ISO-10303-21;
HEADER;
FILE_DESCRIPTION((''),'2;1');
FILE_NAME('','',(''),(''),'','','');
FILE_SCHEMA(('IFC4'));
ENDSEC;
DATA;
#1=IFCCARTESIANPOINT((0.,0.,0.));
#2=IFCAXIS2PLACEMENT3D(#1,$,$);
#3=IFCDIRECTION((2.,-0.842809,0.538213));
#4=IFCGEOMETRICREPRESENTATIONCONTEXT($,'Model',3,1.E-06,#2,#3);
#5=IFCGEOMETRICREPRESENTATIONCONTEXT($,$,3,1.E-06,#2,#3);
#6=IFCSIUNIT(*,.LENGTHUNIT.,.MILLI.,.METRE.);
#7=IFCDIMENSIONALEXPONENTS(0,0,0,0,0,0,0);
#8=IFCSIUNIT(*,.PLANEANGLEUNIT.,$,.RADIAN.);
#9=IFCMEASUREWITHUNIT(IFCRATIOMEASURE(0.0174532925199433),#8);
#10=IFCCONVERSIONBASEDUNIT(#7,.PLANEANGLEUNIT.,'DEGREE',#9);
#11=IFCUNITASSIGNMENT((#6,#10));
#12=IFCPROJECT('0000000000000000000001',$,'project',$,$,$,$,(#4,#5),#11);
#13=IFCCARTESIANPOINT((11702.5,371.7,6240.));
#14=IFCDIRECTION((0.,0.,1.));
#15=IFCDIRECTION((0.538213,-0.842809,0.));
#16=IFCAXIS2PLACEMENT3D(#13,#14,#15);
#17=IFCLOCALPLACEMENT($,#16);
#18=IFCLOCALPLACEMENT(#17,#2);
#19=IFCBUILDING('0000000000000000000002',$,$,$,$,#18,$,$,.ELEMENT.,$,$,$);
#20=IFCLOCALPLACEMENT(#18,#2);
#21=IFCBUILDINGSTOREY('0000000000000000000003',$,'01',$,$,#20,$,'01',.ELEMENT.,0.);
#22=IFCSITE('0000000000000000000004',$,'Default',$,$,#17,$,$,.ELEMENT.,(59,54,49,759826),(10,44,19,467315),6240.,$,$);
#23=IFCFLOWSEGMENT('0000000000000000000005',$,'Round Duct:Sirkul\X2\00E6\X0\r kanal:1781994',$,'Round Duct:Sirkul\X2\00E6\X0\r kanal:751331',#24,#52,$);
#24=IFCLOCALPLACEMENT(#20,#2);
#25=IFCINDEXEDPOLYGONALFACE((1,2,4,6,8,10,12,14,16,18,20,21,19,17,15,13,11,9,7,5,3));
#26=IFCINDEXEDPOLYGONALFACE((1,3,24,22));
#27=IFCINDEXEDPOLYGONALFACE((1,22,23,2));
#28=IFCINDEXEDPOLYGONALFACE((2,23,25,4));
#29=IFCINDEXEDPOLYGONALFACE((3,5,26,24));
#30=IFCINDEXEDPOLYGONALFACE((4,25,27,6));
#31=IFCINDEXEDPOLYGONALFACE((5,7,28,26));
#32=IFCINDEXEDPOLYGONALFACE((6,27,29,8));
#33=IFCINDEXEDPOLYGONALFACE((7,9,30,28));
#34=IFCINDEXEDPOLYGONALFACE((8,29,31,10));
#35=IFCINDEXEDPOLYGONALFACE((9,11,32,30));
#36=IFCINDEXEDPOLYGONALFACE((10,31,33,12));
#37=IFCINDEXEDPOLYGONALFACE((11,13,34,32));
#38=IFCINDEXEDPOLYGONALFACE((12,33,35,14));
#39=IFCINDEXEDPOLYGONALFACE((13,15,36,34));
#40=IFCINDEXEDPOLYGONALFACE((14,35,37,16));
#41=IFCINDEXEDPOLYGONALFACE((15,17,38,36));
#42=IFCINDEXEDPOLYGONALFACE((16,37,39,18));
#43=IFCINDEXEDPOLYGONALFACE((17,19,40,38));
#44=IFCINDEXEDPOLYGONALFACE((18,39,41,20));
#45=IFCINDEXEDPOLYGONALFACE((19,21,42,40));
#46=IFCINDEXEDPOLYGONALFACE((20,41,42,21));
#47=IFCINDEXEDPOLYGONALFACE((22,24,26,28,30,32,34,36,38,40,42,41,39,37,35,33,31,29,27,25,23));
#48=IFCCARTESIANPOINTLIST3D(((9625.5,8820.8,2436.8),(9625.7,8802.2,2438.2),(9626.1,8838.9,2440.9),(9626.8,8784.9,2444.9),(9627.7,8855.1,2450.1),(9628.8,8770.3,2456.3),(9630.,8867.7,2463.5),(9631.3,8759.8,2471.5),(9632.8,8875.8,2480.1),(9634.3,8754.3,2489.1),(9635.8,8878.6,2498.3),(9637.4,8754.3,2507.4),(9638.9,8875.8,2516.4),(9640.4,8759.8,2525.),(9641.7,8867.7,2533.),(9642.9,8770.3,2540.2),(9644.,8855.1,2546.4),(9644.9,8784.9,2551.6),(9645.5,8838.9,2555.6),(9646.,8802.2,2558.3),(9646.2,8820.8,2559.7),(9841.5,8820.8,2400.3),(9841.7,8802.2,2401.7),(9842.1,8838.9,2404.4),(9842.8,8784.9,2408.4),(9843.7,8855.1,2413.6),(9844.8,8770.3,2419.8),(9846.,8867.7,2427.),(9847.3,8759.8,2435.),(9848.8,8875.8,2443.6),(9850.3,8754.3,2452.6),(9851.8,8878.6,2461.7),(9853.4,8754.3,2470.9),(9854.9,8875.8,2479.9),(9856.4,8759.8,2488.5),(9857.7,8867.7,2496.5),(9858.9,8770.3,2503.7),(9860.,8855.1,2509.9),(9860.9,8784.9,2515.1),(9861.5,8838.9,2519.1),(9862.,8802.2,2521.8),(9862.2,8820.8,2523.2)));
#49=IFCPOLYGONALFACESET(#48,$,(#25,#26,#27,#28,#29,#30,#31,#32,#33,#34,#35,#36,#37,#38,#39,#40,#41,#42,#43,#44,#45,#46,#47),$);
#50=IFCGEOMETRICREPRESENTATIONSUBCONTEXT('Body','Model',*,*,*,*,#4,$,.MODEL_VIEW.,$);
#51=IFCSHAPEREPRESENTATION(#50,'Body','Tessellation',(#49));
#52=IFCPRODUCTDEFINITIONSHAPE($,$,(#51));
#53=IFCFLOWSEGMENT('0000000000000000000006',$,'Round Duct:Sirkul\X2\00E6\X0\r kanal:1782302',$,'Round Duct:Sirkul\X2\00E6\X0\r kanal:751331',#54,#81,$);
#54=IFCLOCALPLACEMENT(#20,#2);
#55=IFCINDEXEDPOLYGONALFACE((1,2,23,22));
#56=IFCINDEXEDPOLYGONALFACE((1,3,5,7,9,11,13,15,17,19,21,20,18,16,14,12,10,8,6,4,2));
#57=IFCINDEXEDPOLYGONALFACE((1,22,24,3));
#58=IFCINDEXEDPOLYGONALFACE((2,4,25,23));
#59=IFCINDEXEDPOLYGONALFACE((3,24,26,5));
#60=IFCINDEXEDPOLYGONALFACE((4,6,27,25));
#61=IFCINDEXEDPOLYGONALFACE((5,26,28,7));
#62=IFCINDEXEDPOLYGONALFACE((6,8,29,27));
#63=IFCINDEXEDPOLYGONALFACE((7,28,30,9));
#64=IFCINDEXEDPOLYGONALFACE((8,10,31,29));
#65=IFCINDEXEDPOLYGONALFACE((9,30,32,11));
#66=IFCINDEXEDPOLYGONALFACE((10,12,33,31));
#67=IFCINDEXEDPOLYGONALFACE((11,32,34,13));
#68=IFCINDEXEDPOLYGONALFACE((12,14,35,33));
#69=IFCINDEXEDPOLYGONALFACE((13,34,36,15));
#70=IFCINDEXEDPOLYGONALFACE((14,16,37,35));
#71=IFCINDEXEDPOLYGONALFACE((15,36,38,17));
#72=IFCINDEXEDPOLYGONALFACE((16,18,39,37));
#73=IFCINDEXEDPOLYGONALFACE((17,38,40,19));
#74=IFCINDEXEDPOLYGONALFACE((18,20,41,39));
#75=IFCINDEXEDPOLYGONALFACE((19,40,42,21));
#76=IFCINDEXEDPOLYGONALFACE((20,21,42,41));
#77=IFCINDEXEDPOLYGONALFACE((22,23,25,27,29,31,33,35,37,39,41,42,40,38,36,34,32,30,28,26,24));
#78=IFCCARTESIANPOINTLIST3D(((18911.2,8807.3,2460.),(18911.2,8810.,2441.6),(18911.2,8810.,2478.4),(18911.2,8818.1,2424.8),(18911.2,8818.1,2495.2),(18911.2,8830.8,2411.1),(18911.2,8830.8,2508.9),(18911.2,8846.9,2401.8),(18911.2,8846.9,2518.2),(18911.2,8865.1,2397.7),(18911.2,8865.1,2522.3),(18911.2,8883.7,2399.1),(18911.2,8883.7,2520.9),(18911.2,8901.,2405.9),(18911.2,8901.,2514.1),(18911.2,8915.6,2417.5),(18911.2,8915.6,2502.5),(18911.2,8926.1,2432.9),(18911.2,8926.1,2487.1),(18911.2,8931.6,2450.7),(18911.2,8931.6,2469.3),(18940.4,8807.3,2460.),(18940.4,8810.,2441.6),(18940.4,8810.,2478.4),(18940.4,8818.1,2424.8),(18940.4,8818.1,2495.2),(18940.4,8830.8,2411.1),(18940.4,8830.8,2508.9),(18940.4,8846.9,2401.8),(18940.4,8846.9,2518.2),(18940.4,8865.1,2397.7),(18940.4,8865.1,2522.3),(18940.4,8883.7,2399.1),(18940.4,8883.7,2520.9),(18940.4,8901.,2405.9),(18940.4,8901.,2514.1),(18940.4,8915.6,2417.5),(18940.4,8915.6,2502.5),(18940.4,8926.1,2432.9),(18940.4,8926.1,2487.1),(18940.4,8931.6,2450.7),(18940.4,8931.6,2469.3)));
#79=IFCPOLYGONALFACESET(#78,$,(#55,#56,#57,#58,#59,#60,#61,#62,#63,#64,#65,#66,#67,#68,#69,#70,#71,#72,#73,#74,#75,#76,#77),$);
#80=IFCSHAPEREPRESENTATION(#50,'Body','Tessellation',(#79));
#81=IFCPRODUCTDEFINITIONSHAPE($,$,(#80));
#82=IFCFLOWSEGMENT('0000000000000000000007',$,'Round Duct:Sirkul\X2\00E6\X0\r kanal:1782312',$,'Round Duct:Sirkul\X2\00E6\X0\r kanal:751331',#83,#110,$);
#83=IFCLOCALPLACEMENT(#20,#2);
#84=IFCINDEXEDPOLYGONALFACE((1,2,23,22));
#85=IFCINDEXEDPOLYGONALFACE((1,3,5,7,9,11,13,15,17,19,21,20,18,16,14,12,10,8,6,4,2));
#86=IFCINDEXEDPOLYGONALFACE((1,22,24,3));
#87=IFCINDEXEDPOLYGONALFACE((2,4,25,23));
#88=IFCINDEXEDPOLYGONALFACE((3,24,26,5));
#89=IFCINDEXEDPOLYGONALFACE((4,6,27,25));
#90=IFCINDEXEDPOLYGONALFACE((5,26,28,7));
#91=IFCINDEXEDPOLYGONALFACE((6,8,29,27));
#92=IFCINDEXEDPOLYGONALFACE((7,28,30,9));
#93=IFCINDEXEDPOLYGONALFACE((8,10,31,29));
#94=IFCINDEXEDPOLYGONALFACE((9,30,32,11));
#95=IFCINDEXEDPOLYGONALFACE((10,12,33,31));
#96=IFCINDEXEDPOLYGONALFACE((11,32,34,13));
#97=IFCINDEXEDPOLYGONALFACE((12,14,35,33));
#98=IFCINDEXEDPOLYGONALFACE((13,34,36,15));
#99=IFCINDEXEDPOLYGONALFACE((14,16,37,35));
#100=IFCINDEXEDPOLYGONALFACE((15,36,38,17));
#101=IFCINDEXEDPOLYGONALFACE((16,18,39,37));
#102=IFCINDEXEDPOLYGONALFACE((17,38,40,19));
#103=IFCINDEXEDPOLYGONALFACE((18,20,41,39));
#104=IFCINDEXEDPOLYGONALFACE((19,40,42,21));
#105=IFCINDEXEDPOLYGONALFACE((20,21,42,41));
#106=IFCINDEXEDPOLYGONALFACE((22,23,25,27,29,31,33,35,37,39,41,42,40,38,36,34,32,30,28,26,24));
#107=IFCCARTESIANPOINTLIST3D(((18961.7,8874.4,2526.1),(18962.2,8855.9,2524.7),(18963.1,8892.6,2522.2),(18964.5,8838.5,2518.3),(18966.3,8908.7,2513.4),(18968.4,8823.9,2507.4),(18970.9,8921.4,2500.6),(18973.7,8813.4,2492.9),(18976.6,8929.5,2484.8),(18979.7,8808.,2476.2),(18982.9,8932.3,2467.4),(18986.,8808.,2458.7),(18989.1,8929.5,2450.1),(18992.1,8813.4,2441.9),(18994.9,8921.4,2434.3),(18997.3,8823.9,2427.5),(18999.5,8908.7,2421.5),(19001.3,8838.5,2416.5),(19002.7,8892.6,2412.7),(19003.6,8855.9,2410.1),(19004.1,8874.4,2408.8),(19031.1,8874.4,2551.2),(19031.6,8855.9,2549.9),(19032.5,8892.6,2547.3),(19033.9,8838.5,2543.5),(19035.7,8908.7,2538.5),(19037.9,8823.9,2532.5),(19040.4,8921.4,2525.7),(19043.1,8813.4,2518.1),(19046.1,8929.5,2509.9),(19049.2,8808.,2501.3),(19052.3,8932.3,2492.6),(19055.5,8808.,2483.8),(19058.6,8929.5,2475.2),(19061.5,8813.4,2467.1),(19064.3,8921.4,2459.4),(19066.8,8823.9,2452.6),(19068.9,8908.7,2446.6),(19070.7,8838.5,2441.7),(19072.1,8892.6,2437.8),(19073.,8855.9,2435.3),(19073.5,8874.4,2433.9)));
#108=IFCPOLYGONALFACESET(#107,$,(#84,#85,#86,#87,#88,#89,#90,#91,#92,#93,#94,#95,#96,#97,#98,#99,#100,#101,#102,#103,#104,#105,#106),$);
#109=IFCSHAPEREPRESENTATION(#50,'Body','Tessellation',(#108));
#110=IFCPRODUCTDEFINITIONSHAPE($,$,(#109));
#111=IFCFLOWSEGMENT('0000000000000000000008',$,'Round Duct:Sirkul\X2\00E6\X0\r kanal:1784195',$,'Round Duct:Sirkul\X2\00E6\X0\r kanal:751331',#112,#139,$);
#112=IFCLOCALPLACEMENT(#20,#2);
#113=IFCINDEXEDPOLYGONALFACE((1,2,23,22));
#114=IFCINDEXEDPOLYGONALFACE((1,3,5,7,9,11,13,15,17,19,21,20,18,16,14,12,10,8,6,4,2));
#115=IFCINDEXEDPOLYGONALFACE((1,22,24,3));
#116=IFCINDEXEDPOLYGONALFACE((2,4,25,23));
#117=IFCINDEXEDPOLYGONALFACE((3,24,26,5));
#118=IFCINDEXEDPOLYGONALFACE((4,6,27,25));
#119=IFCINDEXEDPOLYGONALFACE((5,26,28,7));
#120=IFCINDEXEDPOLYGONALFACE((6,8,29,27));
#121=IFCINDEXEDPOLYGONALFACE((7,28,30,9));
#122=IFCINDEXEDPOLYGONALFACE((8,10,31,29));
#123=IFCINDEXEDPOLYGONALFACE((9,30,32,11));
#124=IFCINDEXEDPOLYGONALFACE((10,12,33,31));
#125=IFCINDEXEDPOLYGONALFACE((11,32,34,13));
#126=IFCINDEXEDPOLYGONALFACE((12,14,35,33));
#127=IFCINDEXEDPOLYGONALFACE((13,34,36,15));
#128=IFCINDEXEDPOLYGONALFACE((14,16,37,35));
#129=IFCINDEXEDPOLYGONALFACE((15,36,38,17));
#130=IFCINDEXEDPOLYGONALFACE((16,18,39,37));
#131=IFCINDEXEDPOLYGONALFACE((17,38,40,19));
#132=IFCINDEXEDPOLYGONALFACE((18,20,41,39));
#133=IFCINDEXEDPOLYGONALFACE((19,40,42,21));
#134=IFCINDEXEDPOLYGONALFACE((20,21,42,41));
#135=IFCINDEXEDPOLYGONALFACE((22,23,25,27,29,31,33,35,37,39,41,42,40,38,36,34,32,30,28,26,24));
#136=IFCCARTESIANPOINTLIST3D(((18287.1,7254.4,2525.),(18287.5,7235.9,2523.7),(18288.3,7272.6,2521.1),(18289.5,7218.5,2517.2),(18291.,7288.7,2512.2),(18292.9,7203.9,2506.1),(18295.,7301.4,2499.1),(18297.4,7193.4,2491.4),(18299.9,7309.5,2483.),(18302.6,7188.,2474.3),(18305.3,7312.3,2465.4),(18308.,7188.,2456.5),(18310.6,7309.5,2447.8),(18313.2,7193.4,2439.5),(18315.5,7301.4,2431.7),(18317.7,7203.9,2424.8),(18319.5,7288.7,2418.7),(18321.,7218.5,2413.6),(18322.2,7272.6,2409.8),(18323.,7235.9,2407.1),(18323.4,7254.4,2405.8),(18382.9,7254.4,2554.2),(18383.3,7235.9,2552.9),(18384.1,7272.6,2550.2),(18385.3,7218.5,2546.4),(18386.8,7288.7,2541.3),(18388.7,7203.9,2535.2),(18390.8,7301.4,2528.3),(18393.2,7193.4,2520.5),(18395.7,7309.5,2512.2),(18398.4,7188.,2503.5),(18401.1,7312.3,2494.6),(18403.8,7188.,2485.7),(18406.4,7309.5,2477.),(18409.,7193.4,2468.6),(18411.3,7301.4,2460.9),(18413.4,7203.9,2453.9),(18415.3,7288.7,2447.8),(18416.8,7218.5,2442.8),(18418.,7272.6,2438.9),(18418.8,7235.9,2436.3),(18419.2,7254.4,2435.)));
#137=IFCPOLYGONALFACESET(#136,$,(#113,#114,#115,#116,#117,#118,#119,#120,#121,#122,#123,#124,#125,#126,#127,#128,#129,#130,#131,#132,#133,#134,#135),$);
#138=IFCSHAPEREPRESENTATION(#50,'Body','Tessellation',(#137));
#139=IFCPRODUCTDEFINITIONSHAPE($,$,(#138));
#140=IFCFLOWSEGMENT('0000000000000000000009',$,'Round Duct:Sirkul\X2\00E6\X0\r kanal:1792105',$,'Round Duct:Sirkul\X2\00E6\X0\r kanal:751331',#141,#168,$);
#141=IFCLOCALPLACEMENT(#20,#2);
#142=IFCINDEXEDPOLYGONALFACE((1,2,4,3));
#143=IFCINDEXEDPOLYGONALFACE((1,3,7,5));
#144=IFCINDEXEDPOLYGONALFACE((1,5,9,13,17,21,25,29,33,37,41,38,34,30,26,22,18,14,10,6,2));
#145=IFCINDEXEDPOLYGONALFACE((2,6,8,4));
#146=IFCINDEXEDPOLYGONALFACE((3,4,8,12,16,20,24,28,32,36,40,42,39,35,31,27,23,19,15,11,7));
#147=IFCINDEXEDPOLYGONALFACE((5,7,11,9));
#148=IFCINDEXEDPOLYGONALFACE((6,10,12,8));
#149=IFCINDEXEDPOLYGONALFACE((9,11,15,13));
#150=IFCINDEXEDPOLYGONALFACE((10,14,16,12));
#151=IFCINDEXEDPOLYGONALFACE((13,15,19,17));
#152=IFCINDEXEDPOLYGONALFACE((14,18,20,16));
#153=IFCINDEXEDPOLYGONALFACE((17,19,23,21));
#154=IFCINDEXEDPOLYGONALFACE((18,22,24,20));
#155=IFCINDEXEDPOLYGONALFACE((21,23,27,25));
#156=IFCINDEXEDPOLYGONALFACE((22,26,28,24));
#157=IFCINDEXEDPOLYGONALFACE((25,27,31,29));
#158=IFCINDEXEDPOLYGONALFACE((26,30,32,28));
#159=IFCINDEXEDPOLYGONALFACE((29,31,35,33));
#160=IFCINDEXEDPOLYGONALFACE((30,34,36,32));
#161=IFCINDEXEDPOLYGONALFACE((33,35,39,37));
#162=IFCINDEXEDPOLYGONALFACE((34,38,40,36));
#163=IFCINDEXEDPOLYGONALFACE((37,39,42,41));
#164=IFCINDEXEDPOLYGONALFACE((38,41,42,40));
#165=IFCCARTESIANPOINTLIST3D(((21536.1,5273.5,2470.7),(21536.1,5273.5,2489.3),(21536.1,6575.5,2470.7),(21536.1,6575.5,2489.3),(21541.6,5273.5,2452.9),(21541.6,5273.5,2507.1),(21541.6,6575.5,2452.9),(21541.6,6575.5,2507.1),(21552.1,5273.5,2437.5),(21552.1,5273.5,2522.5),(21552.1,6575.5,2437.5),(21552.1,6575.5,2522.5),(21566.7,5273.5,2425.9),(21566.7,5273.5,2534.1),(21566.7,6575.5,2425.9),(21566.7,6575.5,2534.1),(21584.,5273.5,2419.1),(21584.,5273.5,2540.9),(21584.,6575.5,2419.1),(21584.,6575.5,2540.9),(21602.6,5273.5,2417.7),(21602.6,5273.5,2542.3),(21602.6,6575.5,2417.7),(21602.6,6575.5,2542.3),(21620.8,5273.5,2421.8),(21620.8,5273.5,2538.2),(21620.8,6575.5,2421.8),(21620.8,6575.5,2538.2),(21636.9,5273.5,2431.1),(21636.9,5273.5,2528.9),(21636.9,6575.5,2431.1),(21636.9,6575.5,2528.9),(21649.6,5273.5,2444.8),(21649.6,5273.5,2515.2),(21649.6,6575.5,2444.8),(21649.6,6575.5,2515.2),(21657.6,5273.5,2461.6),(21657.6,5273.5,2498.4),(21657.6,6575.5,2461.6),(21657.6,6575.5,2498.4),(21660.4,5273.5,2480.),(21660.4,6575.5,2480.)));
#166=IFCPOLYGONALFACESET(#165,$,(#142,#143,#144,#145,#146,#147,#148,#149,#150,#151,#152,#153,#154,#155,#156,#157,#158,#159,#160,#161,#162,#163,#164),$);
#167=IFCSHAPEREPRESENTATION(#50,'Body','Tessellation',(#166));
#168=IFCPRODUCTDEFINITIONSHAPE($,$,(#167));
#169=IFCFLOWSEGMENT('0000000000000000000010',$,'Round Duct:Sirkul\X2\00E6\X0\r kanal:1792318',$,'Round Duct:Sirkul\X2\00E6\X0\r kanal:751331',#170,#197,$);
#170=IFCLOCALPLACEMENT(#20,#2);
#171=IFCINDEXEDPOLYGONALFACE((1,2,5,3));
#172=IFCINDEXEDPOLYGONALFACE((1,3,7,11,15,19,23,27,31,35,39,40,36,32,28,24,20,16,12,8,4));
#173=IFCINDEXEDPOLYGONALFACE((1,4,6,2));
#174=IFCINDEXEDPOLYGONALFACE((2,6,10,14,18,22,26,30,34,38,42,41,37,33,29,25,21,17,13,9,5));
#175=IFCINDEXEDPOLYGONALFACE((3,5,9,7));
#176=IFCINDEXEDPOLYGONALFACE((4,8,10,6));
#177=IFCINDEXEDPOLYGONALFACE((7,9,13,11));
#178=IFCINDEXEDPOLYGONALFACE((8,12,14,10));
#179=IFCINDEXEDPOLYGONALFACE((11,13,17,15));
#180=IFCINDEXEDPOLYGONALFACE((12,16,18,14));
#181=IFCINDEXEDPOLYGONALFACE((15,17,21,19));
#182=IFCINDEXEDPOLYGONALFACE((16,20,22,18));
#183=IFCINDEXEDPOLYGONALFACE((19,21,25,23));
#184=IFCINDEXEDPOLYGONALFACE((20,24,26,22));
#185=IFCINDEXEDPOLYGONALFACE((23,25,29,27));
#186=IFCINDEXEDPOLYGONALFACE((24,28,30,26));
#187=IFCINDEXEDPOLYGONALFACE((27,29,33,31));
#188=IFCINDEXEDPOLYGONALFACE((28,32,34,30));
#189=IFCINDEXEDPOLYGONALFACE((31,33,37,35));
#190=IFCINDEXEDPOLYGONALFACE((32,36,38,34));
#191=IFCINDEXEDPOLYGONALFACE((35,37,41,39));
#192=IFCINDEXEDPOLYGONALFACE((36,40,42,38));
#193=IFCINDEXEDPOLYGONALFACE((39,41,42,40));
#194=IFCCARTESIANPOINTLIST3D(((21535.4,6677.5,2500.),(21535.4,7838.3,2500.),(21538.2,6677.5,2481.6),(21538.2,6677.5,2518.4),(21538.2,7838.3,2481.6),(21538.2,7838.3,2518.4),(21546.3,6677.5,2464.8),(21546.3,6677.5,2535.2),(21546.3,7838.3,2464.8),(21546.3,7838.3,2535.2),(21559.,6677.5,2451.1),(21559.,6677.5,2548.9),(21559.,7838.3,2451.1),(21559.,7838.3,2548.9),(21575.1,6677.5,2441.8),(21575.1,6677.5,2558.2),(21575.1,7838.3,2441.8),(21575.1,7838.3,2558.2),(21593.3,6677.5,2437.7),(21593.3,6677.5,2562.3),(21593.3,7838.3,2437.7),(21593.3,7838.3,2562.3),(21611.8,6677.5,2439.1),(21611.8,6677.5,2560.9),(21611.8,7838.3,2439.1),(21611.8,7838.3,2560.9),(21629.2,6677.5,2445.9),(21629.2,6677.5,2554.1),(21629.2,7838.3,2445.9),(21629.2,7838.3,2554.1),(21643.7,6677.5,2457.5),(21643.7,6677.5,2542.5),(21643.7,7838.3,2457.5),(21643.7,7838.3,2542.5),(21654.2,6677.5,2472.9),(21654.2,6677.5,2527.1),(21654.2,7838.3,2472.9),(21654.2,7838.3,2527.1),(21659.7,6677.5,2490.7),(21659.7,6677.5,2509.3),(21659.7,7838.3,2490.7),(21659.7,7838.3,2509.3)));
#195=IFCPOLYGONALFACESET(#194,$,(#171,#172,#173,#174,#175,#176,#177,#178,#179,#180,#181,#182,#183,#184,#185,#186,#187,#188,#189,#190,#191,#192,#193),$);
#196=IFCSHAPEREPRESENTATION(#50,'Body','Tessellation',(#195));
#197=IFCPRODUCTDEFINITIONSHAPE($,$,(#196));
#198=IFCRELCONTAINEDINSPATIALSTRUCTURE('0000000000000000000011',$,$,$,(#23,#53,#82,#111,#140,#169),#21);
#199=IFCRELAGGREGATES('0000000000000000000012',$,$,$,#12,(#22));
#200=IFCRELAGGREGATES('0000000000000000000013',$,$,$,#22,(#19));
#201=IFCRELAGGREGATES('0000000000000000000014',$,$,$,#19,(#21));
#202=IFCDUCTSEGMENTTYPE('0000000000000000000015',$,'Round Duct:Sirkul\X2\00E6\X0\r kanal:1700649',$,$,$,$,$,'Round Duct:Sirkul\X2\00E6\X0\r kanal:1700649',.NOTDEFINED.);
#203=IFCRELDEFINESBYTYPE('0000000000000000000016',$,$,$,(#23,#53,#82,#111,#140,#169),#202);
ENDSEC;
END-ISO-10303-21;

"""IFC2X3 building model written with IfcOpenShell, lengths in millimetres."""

from ifc_helpers import new_model, entity, si_unit, converted_unit, direction, frame, origin, origin_2d_with_axis, place, context, subcontext, project, spatial, circle, extrude, type_object, element, save


model = new_model("IFC2X3")

# Units and contexts
model_context = context("Model", 3, precision=1e-06, world=origin(), true_north=direction((2.0, -0.842809, 0.538213)))
context_of_model = context(None, 3, precision=1e-06, world=origin(), true_north=direction((2.0, -0.842809, 0.538213)))
body_context = subcontext(model_context, "Body", "Model", "MODEL_VIEW")
ifc_project = project(units=[si_unit("LENGTHUNIT", "METRE", prefix="MILLI"), converted_unit("PLANEANGLEUNIT", "DEGREE", entity("IfcRatioMeasure", 0.0174532925199433), si_unit("PLANEANGLEUNIT", "RADIAN"), dimensions=[0, 0, 0, 0, 0, 0, 0])], contexts=[model_context, context_of_model])

# Site, building, storey
site_placement = place(None, frame((11702.5, 371.7, 6240.0), z_axis=(0.0, 0.0, 1.0), x_axis=(0.538213, -0.842809, 0.0)))
site = spatial("IfcSite", under=ifc_project, at=site_placement, Name="Default", CompositionType="ELEMENT", RefLatitude=(59, 54, 49, 759826), RefLongitude=(10, 44, 19, 467315), RefElevation=6240.0)
building_placement = place(site_placement, origin())
building = spatial("IfcBuilding", under=site, at=building_placement, CompositionType="ELEMENT")
storey_placement = place(building_placement, origin())
storey = spatial("IfcBuildingStorey", under=building, at=storey_placement, Name="01", LongName="01", CompositionType="ELEMENT", Elevation=0.0)

# Flow segments
duct_segment_type = type_object("IfcDuctSegmentType", Name="Round Duct:Sirkulær kanal:1700649", ElementType="Round Duct:Sirkulær kanal:1700649", PredefinedType="NOTDEFINED")
flow_segment_1_placement = place(storey_placement, origin())
element("IfcFlowSegment", 1, at=flow_segment_1_placement, inside=storey, type_object=duct_segment_type, Name="Round Duct:Sirkulær kanal:1781994", ObjectType="Round Duct:Sirkulær kanal:751331", context=body_context, shape_type="SweptSolid", body=[
    extrude(circle(Radius=62.5, at=origin_2d_with_axis()), frame((9851.8, 8816.1, 2461.7), z_axis=(-0.986018, 0.0, 0.166639), x_axis=(0.0, 1.0, 0.0)), (0.0, 0.0, 1.0), 219.1),
])
flow_segment_2_placement = place(storey_placement, origin())
element("IfcFlowSegment", 2, at=flow_segment_2_placement, inside=storey, type_object=duct_segment_type, Name="Round Duct:Sirkulær kanal:1782302", ObjectType="Round Duct:Sirkulær kanal:751331", context=body_context, shape_type="SweptSolid", body=[
    extrude(circle(Radius=62.5, at=origin_2d_with_axis()), frame((18911.2, 8869.8, 2460.0), z_axis=(1.0, 0.0, 0.0), x_axis=(0.0, -1.0, 0.0)), (0.0, 0.0, 1.0), 29.2),
])
flow_segment_3_placement = place(storey_placement, origin())
element("IfcFlowSegment", 3, at=flow_segment_3_placement, inside=storey, type_object=duct_segment_type, Name="Round Duct:Sirkulær kanal:1782312", ObjectType="Round Duct:Sirkulær kanal:751331", context=body_context, shape_type="SweptSolid", body=[
    extrude(circle(Radius=62.5, at=origin_2d_with_axis()), frame((18982.9, 8869.8, 2467.4), z_axis=(0.940423, 0.0, 0.340006), x_axis=(0.0, 1.0, 0.0)), (0.0, 0.0, 1.0), 73.8),
])
flow_segment_4_placement = place(storey_placement, origin())
element("IfcFlowSegment", 4, at=flow_segment_4_placement, inside=storey, type_object=duct_segment_type, Name="Round Duct:Sirkulær kanal:1784195", ObjectType="Round Duct:Sirkulær kanal:751331", context=body_context, shape_type="SweptSolid", body=[
    extrude(circle(Radius=62.5, at=origin_2d_with_axis()), frame((18305.3, 7249.8, 2465.4), z_axis=(0.956648, 0.0, 0.291247), x_axis=(0.0, 1.0, 0.0)), (0.0, 0.0, 1.0), 100.1),
])
flow_segment_5_placement = place(storey_placement, origin())
element("IfcFlowSegment", 5, at=flow_segment_5_placement, inside=storey, type_object=duct_segment_type, Name="Round Duct:Sirkulær kanal:1792105", ObjectType="Round Duct:Sirkulær kanal:751331", context=body_context, shape_type="SweptSolid", body=[
    extrude(circle(Radius=62.5, at=origin_2d_with_axis()), frame((21597.9, 5273.5, 2480.0), z_axis=(0.0, 1.0, 0.0), x_axis=(1.0, 0.0, 0.0)), (0.0, 0.0, 1.0), 1302.1),
])
flow_segment_6_placement = place(storey_placement, origin())
element("IfcFlowSegment", 6, at=flow_segment_6_placement, inside=storey, type_object=duct_segment_type, Name="Round Duct:Sirkulær kanal:1792318", ObjectType="Round Duct:Sirkulær kanal:751331", context=body_context, shape_type="SweptSolid", body=[
    extrude(circle(Radius=62.5, at=origin_2d_with_axis()), frame((21597.9, 6677.5, 2500.0), z_axis=(0.0, 1.0, 0.0), x_axis=(-1.0, 0.0, 0.0)), (0.0, 0.0, 1.0), 1160.8),
])

save(model, "model.ifc")
